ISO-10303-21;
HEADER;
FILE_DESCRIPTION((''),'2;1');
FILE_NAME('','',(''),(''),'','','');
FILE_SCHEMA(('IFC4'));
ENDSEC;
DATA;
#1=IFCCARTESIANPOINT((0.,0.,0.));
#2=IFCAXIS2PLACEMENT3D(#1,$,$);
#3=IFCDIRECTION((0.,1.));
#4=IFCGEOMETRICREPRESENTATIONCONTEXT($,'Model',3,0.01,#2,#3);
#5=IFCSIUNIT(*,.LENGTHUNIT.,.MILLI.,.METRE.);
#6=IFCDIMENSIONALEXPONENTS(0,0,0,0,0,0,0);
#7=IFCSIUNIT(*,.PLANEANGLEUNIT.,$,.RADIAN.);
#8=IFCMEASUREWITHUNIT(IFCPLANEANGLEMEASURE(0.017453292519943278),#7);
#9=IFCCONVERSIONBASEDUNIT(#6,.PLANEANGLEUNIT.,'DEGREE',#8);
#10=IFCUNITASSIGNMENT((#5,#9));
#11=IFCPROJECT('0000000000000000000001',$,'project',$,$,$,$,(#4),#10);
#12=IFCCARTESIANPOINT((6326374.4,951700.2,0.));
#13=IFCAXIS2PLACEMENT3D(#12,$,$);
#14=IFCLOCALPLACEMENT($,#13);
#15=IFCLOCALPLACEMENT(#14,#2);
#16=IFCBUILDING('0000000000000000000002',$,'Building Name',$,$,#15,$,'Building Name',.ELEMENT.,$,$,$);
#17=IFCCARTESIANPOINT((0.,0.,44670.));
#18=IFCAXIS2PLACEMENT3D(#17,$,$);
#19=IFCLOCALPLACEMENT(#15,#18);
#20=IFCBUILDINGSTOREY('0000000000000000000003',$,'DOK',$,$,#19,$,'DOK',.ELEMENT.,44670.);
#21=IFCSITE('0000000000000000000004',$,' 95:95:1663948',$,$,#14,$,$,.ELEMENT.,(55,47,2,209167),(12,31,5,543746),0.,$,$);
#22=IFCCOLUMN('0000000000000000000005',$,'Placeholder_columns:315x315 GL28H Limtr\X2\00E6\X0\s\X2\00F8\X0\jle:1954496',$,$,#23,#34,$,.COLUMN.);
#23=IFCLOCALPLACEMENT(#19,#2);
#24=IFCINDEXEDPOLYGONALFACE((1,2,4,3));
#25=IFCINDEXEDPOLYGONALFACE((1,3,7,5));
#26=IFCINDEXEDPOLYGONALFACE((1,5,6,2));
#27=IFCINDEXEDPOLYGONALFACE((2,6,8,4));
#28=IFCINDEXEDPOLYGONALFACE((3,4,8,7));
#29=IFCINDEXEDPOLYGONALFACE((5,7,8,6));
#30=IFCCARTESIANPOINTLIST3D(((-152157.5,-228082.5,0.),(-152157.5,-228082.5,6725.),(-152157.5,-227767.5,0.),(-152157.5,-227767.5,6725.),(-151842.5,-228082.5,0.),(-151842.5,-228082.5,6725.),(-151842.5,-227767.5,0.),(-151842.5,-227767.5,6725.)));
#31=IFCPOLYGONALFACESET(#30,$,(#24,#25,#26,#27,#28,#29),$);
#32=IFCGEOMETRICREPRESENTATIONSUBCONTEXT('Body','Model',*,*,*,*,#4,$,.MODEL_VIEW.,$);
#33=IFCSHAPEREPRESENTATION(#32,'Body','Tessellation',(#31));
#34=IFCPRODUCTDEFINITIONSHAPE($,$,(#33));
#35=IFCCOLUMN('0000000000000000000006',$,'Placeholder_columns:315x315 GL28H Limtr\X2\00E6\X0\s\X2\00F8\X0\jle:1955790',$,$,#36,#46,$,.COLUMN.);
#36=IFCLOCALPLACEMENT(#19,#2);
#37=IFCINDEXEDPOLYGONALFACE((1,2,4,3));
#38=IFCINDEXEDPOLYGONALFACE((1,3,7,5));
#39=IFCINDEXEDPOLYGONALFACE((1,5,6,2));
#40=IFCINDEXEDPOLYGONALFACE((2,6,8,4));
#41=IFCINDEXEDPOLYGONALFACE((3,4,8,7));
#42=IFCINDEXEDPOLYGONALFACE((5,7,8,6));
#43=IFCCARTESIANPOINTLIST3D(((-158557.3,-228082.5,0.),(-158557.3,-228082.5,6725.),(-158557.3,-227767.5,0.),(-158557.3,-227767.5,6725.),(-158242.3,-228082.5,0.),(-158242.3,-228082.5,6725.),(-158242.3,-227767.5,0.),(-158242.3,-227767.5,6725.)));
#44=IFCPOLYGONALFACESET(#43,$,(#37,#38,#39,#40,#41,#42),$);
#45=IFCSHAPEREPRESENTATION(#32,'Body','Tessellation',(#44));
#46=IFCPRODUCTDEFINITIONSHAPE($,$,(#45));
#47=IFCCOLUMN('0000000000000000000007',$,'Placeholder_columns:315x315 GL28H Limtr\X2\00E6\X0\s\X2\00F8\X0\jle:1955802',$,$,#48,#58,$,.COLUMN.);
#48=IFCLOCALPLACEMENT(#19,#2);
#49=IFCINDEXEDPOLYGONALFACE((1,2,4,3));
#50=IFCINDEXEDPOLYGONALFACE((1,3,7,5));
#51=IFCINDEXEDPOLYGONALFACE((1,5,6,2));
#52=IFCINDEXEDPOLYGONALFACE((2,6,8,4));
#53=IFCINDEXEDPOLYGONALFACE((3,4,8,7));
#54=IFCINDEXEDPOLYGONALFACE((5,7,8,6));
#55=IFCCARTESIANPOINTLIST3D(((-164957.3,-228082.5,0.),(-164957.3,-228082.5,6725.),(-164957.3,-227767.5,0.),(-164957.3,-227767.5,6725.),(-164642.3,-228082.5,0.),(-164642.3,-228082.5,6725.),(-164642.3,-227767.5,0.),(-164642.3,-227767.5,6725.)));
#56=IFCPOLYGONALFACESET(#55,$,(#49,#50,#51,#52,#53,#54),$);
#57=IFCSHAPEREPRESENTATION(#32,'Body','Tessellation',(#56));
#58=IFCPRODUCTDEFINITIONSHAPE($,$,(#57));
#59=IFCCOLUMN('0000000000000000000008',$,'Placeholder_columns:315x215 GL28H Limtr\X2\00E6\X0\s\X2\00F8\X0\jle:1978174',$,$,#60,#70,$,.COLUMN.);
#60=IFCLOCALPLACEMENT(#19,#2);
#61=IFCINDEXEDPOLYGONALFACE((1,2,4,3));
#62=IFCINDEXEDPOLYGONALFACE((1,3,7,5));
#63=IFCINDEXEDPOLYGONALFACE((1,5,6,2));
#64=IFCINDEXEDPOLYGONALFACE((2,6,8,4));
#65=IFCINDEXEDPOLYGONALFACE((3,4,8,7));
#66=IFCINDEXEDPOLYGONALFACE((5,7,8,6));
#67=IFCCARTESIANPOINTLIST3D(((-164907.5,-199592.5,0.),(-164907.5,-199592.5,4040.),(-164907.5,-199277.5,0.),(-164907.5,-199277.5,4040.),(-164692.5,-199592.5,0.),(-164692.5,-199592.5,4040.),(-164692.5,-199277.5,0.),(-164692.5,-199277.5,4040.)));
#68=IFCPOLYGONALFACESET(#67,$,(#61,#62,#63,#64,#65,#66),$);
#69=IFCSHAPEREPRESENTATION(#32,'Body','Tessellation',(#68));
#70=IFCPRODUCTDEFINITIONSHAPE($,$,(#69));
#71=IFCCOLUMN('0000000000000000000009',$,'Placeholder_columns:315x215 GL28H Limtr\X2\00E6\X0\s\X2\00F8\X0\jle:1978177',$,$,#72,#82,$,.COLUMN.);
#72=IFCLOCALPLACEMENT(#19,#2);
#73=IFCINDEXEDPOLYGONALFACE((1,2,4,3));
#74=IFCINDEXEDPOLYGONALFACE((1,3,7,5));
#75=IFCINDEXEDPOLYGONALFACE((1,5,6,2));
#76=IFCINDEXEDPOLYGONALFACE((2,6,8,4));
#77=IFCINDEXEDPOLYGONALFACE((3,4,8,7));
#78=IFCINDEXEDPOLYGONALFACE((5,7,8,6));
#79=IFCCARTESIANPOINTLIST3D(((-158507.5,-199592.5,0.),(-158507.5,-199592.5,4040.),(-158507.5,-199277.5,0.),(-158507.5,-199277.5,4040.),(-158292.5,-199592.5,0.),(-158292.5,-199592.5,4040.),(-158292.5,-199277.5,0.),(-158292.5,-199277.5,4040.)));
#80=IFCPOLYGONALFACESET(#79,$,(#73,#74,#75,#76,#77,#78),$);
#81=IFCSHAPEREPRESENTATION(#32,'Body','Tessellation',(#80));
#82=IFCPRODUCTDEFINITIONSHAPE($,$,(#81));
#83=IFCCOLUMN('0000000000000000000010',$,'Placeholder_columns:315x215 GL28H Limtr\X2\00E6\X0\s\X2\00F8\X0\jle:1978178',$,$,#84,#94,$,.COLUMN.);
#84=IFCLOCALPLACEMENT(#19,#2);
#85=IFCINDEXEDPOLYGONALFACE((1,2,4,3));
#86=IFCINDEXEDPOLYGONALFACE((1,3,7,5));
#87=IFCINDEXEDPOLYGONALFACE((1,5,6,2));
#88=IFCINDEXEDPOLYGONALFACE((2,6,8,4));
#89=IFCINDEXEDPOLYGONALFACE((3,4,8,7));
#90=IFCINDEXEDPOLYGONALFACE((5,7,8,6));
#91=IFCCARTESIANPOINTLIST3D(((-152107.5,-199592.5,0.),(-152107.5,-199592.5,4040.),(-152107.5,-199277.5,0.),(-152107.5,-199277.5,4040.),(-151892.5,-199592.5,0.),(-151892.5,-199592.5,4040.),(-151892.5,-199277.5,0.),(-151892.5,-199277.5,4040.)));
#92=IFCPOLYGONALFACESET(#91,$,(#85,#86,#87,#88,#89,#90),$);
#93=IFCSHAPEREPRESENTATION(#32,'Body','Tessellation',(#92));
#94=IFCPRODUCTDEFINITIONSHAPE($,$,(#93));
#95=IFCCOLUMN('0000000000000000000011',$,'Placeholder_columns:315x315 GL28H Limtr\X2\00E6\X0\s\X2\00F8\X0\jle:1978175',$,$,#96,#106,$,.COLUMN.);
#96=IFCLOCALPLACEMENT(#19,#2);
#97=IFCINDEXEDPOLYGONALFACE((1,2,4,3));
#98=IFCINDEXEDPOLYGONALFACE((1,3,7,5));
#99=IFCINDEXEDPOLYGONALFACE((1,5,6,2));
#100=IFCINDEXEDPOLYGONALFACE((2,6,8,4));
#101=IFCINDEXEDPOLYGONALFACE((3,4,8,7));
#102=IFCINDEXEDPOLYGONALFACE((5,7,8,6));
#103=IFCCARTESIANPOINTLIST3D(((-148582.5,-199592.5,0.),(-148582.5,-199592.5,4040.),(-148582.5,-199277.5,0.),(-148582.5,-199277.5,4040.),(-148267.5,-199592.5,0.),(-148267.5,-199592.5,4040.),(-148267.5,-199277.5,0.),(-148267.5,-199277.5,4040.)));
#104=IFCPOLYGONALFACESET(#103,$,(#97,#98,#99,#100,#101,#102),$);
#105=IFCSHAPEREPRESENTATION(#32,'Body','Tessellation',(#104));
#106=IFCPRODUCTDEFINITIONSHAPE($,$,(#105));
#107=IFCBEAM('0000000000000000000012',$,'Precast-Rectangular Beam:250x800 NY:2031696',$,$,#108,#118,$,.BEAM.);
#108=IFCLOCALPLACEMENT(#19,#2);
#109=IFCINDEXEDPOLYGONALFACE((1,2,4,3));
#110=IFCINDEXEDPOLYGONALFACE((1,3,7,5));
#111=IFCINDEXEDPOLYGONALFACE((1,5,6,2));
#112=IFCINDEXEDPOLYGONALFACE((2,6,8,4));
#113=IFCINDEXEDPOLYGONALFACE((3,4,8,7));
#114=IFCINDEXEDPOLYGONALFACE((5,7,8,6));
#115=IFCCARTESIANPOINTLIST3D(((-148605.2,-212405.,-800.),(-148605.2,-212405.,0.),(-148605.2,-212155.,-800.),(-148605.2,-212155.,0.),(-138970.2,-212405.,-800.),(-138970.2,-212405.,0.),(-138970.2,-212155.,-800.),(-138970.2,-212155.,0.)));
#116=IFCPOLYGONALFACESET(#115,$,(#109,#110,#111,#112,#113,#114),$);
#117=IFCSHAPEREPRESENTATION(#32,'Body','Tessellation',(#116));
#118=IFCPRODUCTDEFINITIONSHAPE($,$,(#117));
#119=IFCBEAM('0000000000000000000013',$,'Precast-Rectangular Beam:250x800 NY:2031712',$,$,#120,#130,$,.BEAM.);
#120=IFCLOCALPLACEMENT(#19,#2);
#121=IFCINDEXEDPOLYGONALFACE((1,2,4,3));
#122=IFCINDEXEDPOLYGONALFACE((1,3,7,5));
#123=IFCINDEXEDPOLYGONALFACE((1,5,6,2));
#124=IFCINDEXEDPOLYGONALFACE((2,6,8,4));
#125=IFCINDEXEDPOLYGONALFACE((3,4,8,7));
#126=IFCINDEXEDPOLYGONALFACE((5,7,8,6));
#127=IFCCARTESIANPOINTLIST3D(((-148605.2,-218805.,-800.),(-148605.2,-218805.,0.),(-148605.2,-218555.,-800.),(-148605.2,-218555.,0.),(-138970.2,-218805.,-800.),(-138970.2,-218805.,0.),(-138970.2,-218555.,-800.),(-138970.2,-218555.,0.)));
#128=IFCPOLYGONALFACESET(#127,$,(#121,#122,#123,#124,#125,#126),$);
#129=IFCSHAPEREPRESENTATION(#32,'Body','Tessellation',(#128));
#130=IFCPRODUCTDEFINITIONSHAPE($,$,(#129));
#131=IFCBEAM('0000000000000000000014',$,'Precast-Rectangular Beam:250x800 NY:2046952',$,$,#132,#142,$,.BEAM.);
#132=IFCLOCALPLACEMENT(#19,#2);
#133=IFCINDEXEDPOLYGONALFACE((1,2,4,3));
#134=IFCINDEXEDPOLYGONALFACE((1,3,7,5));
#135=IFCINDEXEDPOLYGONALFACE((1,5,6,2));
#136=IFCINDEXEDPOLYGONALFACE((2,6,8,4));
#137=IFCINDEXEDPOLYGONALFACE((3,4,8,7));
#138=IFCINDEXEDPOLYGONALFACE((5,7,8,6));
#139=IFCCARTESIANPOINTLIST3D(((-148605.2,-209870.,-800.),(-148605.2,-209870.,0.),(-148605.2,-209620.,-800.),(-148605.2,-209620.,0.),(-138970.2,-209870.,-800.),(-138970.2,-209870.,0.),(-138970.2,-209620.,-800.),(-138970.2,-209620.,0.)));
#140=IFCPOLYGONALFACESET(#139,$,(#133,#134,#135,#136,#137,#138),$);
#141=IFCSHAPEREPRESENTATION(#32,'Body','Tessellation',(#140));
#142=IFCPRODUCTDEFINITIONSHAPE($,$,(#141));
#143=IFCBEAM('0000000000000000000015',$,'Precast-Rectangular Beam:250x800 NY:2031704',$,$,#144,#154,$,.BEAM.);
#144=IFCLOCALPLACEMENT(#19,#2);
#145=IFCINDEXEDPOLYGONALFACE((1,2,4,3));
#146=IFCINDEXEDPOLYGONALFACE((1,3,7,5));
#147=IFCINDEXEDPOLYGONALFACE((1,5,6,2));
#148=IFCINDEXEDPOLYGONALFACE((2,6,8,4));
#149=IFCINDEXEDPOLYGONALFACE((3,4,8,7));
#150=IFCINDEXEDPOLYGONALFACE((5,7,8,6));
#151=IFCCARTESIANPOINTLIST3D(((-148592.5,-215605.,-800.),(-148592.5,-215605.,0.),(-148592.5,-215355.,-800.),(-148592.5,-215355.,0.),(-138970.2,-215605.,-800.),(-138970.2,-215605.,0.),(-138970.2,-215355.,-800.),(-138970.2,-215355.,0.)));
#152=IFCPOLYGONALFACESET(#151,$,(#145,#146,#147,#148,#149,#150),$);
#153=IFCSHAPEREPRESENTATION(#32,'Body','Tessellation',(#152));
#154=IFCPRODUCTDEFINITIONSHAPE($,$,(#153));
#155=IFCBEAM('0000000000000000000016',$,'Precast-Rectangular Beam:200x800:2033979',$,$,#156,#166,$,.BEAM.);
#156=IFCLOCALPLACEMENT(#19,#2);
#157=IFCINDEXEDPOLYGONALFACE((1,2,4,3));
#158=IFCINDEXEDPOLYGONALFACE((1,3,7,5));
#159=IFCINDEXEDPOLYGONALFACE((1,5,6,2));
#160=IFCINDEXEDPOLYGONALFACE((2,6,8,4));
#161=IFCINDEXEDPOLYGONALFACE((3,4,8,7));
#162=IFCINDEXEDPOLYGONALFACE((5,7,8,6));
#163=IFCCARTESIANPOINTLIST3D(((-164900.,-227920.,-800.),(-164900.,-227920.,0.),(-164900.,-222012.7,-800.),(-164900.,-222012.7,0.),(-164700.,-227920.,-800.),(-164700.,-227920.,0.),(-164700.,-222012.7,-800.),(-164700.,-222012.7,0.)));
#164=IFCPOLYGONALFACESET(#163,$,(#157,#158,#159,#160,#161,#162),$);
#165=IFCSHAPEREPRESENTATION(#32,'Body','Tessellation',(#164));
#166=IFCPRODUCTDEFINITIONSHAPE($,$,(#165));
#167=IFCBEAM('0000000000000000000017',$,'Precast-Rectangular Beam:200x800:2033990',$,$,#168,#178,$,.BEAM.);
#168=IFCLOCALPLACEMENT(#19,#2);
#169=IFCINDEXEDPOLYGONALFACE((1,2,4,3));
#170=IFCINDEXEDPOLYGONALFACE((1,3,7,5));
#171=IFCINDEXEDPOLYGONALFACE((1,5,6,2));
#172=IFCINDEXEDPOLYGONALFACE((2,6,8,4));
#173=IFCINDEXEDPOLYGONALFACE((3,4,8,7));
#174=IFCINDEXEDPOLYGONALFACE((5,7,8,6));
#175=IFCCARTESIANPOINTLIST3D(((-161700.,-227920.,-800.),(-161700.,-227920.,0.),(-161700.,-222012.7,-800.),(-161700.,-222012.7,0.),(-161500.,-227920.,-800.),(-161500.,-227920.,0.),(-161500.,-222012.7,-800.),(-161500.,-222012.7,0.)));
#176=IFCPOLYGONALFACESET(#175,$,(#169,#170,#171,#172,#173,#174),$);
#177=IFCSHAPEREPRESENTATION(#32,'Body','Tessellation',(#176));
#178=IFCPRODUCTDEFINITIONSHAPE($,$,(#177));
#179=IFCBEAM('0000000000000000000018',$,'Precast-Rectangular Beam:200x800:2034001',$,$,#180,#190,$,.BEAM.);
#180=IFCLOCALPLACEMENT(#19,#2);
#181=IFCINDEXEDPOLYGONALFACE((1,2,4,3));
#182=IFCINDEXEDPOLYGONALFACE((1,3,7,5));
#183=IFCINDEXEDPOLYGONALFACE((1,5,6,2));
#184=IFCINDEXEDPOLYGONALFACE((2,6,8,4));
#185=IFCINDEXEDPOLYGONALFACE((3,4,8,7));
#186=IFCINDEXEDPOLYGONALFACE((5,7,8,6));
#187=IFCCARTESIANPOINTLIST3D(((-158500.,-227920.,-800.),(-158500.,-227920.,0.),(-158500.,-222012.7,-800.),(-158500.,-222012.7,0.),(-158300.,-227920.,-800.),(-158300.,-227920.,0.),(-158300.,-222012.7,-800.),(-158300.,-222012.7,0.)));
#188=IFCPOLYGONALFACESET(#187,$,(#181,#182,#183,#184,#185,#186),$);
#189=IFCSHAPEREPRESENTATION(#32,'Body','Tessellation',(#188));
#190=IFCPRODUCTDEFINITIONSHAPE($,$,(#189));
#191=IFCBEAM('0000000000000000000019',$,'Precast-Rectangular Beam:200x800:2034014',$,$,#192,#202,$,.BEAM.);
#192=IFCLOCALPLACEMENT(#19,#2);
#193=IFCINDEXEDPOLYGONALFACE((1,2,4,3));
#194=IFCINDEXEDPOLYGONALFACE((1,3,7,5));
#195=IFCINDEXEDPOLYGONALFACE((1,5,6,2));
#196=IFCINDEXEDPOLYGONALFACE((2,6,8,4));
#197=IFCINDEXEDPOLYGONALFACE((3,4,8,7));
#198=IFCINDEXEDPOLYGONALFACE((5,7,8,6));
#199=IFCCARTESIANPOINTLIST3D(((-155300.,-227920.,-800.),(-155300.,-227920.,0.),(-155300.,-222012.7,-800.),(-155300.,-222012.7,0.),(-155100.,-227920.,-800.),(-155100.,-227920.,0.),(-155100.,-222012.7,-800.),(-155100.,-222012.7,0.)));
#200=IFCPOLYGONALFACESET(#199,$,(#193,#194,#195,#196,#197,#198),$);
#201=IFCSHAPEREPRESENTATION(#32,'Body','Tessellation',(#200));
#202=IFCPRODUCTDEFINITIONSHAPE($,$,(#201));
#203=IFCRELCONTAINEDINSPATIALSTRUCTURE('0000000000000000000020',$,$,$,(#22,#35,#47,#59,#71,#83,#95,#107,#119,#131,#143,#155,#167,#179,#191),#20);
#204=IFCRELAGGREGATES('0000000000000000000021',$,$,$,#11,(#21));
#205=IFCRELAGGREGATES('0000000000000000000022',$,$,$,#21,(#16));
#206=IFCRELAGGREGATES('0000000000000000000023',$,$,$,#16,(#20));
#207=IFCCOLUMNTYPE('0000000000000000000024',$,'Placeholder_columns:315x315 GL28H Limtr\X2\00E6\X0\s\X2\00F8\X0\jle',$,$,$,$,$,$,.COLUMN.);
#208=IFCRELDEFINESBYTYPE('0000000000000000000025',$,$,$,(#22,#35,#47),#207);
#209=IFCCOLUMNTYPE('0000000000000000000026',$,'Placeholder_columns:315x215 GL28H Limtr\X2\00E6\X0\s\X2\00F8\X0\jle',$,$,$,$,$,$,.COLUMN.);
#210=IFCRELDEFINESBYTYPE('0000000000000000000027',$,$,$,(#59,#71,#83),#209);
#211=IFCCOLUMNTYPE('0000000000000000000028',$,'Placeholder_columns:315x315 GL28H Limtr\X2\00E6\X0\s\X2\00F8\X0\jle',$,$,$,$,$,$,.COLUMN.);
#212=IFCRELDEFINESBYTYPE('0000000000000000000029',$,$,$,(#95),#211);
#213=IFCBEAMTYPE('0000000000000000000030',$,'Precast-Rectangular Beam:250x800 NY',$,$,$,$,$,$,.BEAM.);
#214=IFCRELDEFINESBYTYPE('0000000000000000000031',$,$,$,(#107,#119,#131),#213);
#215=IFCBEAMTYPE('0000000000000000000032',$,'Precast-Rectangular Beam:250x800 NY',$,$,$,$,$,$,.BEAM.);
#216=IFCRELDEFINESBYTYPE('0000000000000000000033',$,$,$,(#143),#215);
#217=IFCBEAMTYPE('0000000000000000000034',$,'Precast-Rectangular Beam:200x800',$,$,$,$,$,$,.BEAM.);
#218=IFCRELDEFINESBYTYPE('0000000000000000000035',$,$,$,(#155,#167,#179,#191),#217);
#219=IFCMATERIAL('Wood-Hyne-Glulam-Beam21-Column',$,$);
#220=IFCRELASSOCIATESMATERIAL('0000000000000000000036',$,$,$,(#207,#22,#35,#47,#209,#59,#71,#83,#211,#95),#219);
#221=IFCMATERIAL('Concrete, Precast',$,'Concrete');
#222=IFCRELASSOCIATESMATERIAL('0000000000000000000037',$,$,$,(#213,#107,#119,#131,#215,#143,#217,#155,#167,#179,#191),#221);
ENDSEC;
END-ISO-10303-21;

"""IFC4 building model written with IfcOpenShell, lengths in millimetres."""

from ifc_helpers import new_model, entity, si_unit, converted_unit, direction, frame, origin, place, context, subcontext, project, spatial, indexed_curve, outline, extrude, source, transform, mapped, material, type_object, type_shapes, element, save


model = new_model("IFC4")

# Units and contexts
model_context = context("Model", 3, precision=0.01, world=origin(), true_north=direction((0.0, 1.0)))
body_context = subcontext(model_context, "Body", "Model", "MODEL_VIEW")
ifc_project = project(units=[si_unit("LENGTHUNIT", "METRE", prefix="MILLI"), converted_unit("PLANEANGLEUNIT", "DEGREE", entity("IfcPlaneAngleMeasure", 0.017453292519943278), si_unit("PLANEANGLEUNIT", "RADIAN"), dimensions=[0, 0, 0, 0, 0, 0, 0])], contexts=[model_context])

# Site, building, storey
site_placement = place(None, frame((6326374.4, 951700.2, 0.0)))
site = spatial("IfcSite", under=ifc_project, at=site_placement, Name=" 95:95:1663948", CompositionType="ELEMENT", RefLatitude=(55, 47, 2, 209167), RefLongitude=(12, 31, 5, 543746), RefElevation=0.0)
building_placement = place(site_placement, origin())
building = spatial("IfcBuilding", under=site, at=building_placement, Name="Building Name", LongName="Building Name", CompositionType="ELEMENT")
storey_placement = place(building_placement, frame((0.0, 0.0, 44670.0)))
storey = spatial("IfcBuildingStorey", under=building, at=storey_placement, Name="DOK", LongName="DOK", CompositionType="ELEMENT", Elevation=44670.0)

# Columns
ifc_material_1 = material(Name="Wood-Hyne-Glulam-Beam21-Column")
column_type_1 = type_object("IfcColumnType", Name="Placeholder_columns:315x315 GL28H Limtræsøjle", PredefinedType="COLUMN", material=ifc_material_1)
shared_shape_1 = source(origin(), body_context, "Body", "SweptSolid", [
    extrude(outline(indexed_curve([(-157.5, -157.5), (157.5, -157.5), (157.5, 157.5), (-157.5, 157.5), (-157.5, -157.5)], self_intersect=False)), frame((0.0, 0.0, 44670.0), z_axis=(0.0, 0.0, 1.0), x_axis=(-1.0, 0.0, 0.0)), (0.0, 0.0, 1.0), 6725.0),
])
type_shapes(column_type_1, [shared_shape_1])
for number, where, name in (
    (1, (-152000.0, -227925.0, -44670.0), "Placeholder_columns:315x315 GL28H Limtræsøjle:1954496"),
    (2, (-158399.8, -227925.0, -44670.0), "Placeholder_columns:315x315 GL28H Limtræsøjle:1955790"),
    (3, (-164799.8, -227925.0, -44670.0), "Placeholder_columns:315x315 GL28H Limtræsøjle:1955802"),
):
    element("IfcColumn", number, at=place(storey_placement, frame(where)), inside=storey, type_object=column_type_1, material=ifc_material_1, Name=name, PredefinedType="COLUMN", context=body_context, shape_type="MappedRepresentation", body=[
        mapped(shared_shape_1, transform((0.0, 0.0, 0.0), scale=1.0)),
    ])
column_type_2 = type_object("IfcColumnType", Name="Placeholder_columns:315x215 GL28H Limtræsøjle", PredefinedType="COLUMN", material=ifc_material_1)
shared_shape_2 = source(origin(), body_context, "Body", "SweptSolid", [
    extrude(outline(indexed_curve([(-107.5, -157.5), (107.5, -157.5), (107.5, 157.5), (-107.5, 157.5), (-107.5, -157.5)], self_intersect=False)), frame((0.0, 0.0, 44670.0), z_axis=(0.0, 0.0, 1.0), x_axis=(-1.0, 0.0, 0.0)), (0.0, 0.0, 1.0), 4040.0),
])
type_shapes(column_type_2, [shared_shape_2])
for number, where, name in (
    (4, (-164800.0, -199435.0, -44670.0), "Placeholder_columns:315x215 GL28H Limtræsøjle:1978174"),
    (5, (-158400.0, -199435.0, -44670.0), "Placeholder_columns:315x215 GL28H Limtræsøjle:1978177"),
    (6, (-152000.0, -199435.0, -44670.0), "Placeholder_columns:315x215 GL28H Limtræsøjle:1978178"),
):
    element("IfcColumn", number, at=place(storey_placement, frame(where)), inside=storey, type_object=column_type_2, material=ifc_material_1, Name=name, PredefinedType="COLUMN", context=body_context, shape_type="MappedRepresentation", body=[
        mapped(shared_shape_2, transform((0.0, 0.0, 0.0), scale=1.0)),
    ])
column_type_3 = type_object("IfcColumnType", Name="Placeholder_columns:315x315 GL28H Limtræsøjle", PredefinedType="COLUMN", material=ifc_material_1)
shared_shape_3 = source(origin(), body_context, "Body", "SweptSolid", [
    extrude(outline(indexed_curve([(-157.5, -157.5), (157.5, -157.5), (157.5, 157.5), (-157.5, 157.5), (-157.5, -157.5)], self_intersect=False)), frame((0.0, 0.0, 44670.0), z_axis=(0.0, 0.0, 1.0), x_axis=(-1.0, 0.0, 0.0)), (0.0, 0.0, 1.0), 4040.0),
])
type_shapes(column_type_3, [shared_shape_3])
column_placement = place(storey_placement, frame((-148425.0, -199435.0, -44670.0)))
element("IfcColumn", 7, at=column_placement, inside=storey, type_object=column_type_3, material=ifc_material_1, Name="Placeholder_columns:315x315 GL28H Limtræsøjle:1978175", PredefinedType="COLUMN", context=body_context, shape_type="MappedRepresentation", body=[
    mapped(shared_shape_3, transform((0.0, 0.0, 0.0), scale=1.0)),
])

# Beams
ifc_material_2 = material(Name="Concrete, Precast", Category="Concrete")
beam_type_1 = type_object("IfcBeamType", Name="Precast-Rectangular Beam:250x800 NY", PredefinedType="BEAM", material=ifc_material_2)
shared_shape_4 = source(origin(), body_context, "Body", "SweptSolid", [
    extrude(outline(indexed_curve([(-4817.5, -125.0), (4817.5, -125.0), (4817.5, 125.0), (-4817.5, 125.0), (-4817.5, -125.0)], self_intersect=False)), frame((62.5, 0.0, -400.0), z_axis=(0.0, 0.0, 1.0), x_axis=(-1.0, 0.0, 0.0)), (0.0, 0.0, 1.0), 800.0),
])
type_shapes(beam_type_1, [shared_shape_4])
for number, where, name in (
    (8, (-143850.2, -212280.0, -400.0), "Precast-Rectangular Beam:250x800 NY:2031696"),
    (9, (-143850.2, -218680.0, -400.0), "Precast-Rectangular Beam:250x800 NY:2031712"),
    (10, (-143850.2, -209745.0, -400.0), "Precast-Rectangular Beam:250x800 NY:2046952"),
):
    element("IfcBeam", number, at=place(storey_placement, frame(where)), inside=storey, type_object=beam_type_1, material=ifc_material_2, Name=name, PredefinedType="BEAM", context=body_context, shape_type="MappedRepresentation", body=[
        mapped(shared_shape_4, transform((0.0, 0.0, 0.0), scale=1.0)),
    ])
beam_type_2 = type_object("IfcBeamType", Name="Precast-Rectangular Beam:250x800 NY", PredefinedType="BEAM", material=ifc_material_2)
shared_shape_5 = source(origin(), body_context, "Body", "SweptSolid", [
    extrude(outline(indexed_curve([(-4811.1, -125.0), (4811.1, -125.0), (4811.1, 125.0), (-4811.1, 125.0), (-4811.1, -125.0)], self_intersect=False)), frame((68.9, 0.0, -400.0), z_axis=(0.0, 0.0, 1.0), x_axis=(-1.0, 0.0, 0.0)), (0.0, 0.0, 1.0), 800.0),
])
type_shapes(beam_type_2, [shared_shape_5])
beam_1_placement = place(storey_placement, frame((-143850.2, -215480.0, -400.0)))
element("IfcBeam", 11, at=beam_1_placement, inside=storey, type_object=beam_type_2, material=ifc_material_2, Name="Precast-Rectangular Beam:250x800 NY:2031704", PredefinedType="BEAM", context=body_context, shape_type="MappedRepresentation", body=[
    mapped(shared_shape_5, transform((0.0, 0.0, 0.0), scale=1.0)),
])
beam_type_3 = type_object("IfcBeamType", Name="Precast-Rectangular Beam:200x800", PredefinedType="BEAM", material=ifc_material_2)
shared_shape_6 = source(origin(), body_context, "Body", "SweptSolid", [
    extrude(outline(indexed_curve([(-2953.7, -100.0), (2953.7, -100.0), (2953.7, 100.0), (-2953.7, 100.0), (-2953.7, -100.0)], self_intersect=False)), frame((-66.4, 0.0, -400.0), z_axis=(0.0, 0.0, 1.0), x_axis=(-1.0, 0.0, 0.0)), (0.0, 0.0, 1.0), 800.0),
])
type_shapes(beam_type_3, [shared_shape_6])
for number, where, z_axis, x_axis, name in (
    (12, (-164800.0, -224900.0, -400.0), (0.0, 0.0, 1.0), (0.0, 1.0, 0.0), "Precast-Rectangular Beam:200x800:2033979"),
    (13, (-161600.0, -224900.0, -400.0), (0.0, 0.0, 1.0), (0.0, 1.0, 0.0), "Precast-Rectangular Beam:200x800:2033990"),
    (14, (-158400.0, -224900.0, -400.0), (0.0, 0.0, 1.0), (0.0, 1.0, 0.0), "Precast-Rectangular Beam:200x800:2034001"),
    (15, (-155200.0, -224900.0, -400.0), (0.0, 0.0, 1.0), (0.0, 1.0, 0.0), "Precast-Rectangular Beam:200x800:2034014"),
):
    element("IfcBeam", number, at=place(storey_placement, frame(where, z_axis=z_axis, x_axis=x_axis)), inside=storey, type_object=beam_type_3, material=ifc_material_2, Name=name, PredefinedType="BEAM", context=body_context, shape_type="MappedRepresentation", body=[
        mapped(shared_shape_6, transform((0.0, 0.0, 0.0), scale=1.0)),
    ])

save(model, "model.ifc")
